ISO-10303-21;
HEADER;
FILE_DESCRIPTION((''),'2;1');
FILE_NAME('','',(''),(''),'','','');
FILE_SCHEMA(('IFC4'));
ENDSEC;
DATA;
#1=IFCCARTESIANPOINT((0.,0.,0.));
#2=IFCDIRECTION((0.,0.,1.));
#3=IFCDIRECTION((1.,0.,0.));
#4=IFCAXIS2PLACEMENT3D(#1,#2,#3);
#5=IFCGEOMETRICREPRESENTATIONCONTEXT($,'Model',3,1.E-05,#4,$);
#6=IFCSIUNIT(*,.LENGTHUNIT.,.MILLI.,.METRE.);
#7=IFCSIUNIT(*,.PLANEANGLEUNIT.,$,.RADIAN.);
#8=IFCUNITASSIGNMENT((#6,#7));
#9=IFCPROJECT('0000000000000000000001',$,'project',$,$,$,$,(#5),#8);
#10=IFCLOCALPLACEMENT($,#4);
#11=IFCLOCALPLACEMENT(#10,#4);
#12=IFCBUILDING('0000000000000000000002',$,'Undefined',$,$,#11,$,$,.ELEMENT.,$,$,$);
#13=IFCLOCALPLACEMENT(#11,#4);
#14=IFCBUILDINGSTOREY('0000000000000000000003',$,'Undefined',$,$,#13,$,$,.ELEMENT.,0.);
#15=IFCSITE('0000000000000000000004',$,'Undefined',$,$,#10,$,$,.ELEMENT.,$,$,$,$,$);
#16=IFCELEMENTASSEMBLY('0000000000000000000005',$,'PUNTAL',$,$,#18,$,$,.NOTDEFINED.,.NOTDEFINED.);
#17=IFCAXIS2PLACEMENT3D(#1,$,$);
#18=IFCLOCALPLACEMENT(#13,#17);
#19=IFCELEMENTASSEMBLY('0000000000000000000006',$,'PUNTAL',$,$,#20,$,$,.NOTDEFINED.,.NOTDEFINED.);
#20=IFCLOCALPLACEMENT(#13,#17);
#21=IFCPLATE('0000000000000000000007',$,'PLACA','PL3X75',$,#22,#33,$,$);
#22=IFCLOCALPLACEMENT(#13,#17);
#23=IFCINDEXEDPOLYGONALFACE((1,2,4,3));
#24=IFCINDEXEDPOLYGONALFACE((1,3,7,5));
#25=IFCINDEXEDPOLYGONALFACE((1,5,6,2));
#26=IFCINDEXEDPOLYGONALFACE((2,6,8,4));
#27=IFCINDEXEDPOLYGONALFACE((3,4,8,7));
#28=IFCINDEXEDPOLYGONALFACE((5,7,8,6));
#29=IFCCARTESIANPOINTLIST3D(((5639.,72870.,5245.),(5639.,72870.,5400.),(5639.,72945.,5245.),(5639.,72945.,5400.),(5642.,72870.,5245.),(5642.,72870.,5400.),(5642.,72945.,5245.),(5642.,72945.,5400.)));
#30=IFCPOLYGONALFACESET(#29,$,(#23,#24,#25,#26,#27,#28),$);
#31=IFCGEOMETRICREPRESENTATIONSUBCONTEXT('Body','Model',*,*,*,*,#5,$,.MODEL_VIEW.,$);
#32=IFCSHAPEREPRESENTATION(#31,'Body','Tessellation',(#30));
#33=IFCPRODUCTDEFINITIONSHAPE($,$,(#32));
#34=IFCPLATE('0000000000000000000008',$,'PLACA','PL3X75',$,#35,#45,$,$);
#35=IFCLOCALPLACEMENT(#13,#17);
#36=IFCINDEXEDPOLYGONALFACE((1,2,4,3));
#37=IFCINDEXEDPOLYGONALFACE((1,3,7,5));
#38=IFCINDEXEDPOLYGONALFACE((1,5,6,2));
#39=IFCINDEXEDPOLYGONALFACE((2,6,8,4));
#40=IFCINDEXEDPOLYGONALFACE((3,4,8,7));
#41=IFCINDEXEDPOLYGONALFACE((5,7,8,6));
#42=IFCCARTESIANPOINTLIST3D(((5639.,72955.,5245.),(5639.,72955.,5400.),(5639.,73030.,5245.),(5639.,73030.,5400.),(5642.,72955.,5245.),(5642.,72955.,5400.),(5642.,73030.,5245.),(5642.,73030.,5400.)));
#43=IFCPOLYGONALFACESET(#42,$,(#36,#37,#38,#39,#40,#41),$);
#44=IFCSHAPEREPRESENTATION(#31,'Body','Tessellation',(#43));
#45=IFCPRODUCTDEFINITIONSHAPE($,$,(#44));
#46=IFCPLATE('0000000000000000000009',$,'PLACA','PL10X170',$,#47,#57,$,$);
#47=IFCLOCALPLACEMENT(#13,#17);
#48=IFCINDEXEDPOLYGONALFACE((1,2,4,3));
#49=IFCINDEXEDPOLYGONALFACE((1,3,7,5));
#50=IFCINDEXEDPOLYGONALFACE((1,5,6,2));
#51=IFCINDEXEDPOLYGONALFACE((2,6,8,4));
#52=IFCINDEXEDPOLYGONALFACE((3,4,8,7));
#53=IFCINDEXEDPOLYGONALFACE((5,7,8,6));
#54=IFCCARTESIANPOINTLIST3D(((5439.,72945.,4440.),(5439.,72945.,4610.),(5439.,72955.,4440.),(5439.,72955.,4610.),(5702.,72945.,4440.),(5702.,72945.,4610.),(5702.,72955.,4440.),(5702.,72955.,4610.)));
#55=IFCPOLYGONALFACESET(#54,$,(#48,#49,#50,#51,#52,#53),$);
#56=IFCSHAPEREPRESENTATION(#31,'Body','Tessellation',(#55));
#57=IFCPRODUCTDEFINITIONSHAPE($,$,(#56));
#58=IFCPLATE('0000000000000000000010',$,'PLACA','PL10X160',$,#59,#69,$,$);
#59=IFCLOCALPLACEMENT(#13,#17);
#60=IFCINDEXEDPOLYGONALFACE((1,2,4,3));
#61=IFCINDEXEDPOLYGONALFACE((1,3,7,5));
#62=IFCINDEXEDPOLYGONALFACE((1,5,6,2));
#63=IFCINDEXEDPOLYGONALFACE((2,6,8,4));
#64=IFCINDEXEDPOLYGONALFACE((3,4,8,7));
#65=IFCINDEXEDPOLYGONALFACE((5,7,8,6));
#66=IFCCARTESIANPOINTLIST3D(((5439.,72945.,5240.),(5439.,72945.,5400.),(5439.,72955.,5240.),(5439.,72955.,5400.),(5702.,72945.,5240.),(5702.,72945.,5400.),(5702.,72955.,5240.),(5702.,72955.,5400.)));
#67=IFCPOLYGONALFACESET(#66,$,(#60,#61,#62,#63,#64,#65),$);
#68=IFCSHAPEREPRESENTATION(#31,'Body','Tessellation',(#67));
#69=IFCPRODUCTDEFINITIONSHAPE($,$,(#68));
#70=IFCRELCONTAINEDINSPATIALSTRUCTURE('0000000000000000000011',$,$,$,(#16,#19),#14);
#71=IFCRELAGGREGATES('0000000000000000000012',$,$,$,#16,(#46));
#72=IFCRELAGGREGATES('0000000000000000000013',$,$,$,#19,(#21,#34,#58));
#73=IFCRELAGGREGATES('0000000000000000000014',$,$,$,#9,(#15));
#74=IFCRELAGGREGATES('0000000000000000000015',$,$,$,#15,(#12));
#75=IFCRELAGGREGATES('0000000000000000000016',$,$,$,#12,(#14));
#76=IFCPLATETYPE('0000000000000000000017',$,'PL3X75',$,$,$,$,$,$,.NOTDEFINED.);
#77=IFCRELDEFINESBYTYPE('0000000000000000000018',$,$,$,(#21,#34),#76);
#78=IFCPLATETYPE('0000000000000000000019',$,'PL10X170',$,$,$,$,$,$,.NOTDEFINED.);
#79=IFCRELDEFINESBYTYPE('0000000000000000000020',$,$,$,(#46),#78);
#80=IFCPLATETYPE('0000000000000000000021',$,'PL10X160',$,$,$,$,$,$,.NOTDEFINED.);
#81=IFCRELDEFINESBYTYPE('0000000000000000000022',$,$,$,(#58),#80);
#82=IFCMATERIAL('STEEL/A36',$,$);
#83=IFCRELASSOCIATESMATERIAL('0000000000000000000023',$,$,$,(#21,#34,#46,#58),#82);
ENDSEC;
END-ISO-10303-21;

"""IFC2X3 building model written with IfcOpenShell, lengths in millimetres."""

from ifc_helpers import new_model, si_unit, frame, origin_with_axes, place, context, subcontext, project, spatial, polyline, outline, extrude, material, type_object, element, aggregate, save


model = new_model("IFC2X3")

# Units and contexts
model_context = context("Model", 3, precision=1e-05, world=origin_with_axes())
body_context = subcontext(model_context, "Body", "Model", "MODEL_VIEW")
ifc_project = project(units=[si_unit("LENGTHUNIT", "METRE", prefix="MILLI"), si_unit("PLANEANGLEUNIT", "RADIAN")], contexts=[model_context])

# Site, building, storey
site_placement = place(None, origin_with_axes())
site = spatial("IfcSite", under=ifc_project, at=site_placement, Name="Undefined", CompositionType="ELEMENT")
building_placement = place(site_placement, origin_with_axes())
building = spatial("IfcBuilding", under=site, at=building_placement, Name="Undefined", CompositionType="ELEMENT")
storey_placement = place(building_placement, origin_with_axes())
storey = spatial("IfcBuildingStorey", under=building, at=storey_placement, Name="Undefined", CompositionType="ELEMENT", Elevation=0.0)

# Shared definitions
ifc_material_1 = material(Name="STEEL/A36")

# Element assemblies, plates
assembly_1_placement = place(storey_placement, origin_with_axes())
assembly_1 = element("IfcElementAssembly", 1, at=assembly_1_placement, inside=storey, Name="PUNTAL", AssemblyPlace="NOTDEFINED", PredefinedType="NOTDEFINED")
plate_type_1 = type_object("IfcPlateType", Name="PL3X75", PredefinedType="NOTDEFINED")
assembly_2_placement = place(storey_placement, origin_with_axes())
assembly_2 = element("IfcElementAssembly", 2, at=assembly_2_placement, inside=storey, Name="PUNTAL", AssemblyPlace="NOTDEFINED", PredefinedType="NOTDEFINED")
plate_1_placement = place(assembly_2_placement, frame((5640.5, 72870.0, 5245.0), z_axis=(1.0, 0.0, 0.0), x_axis=(0.0, 1.0, 0.0)))
plate_1 = element("IfcPlate", 3, at=plate_1_placement, type_object=plate_type_1, material=ifc_material_1, Name="PLACA", Description="PL3X75", context=body_context, shape_type="SweptSolid", body=[
    extrude(outline(polyline([(0.0, 0.0), (75.0, 0.0), (75.0, 155.0), (0.0, 155.0), (0.0, 0.0)])), frame((0.0, 0.0, -1.5), z_axis=(0.0, 0.0, 1.0), x_axis=(1.0, 0.0, 0.0)), (0.0, 0.0, 1.0), 3.0),
])
plate_2_placement = place(assembly_2_placement, frame((5640.5, 72955.0, 5245.0), z_axis=(1.0, 0.0, 0.0), x_axis=(0.0, 1.0, 0.0)))
plate_2 = element("IfcPlate", 4, at=plate_2_placement, type_object=plate_type_1, material=ifc_material_1, Name="PLACA", Description="PL3X75", context=body_context, shape_type="SweptSolid", body=[
    extrude(outline(polyline([(0.0, 0.0), (75.0, 0.0), (75.0, 155.0), (0.0, 155.0), (0.0, 0.0)])), frame((0.0, 0.0, -1.5), z_axis=(0.0, 0.0, 1.0), x_axis=(1.0, 0.0, 0.0)), (0.0, 0.0, 1.0), 3.0),
])

# Plates
plate_type_2 = type_object("IfcPlateType", Name="PL10X170", PredefinedType="NOTDEFINED")
plate_3_placement = place(assembly_1_placement, frame((5702.0, 72950.0, 4525.0), z_axis=(0.0, 1.0, 0.0), x_axis=(-1.0, 0.0, 0.0)))
plate_3 = element("IfcPlate", 5, at=plate_3_placement, type_object=plate_type_2, material=ifc_material_1, Name="PLACA", Description="PL10X170", context=body_context, shape_type="SweptSolid", body=[
    extrude(outline(polyline([(0.0, -85.0), (0.0, 85.0), (263.0, 85.0), (263.0, -85.0), (0.0, -85.0)])), frame((0.0, 0.0, -5.0), z_axis=(0.0, 0.0, 1.0), x_axis=(1.0, 0.0, 0.0)), (0.0, 0.0, 1.0), 10.0),
])
aggregate(assembly_1, [plate_3])
plate_type_3 = type_object("IfcPlateType", Name="PL10X160", PredefinedType="NOTDEFINED")
plate_4_placement = place(assembly_2_placement, frame((5702.0, 72950.0, 5320.0), z_axis=(0.0, -1.0, 0.0), x_axis=(-1.0, 0.0, 0.0)))
plate_4 = element("IfcPlate", 6, at=plate_4_placement, type_object=plate_type_3, material=ifc_material_1, Name="PLACA", Description="PL10X160", context=body_context, shape_type="SweptSolid", body=[
    extrude(outline(polyline([(0.0, -80.0), (0.0, 80.0), (263.0, 80.0), (263.0, -80.0), (0.0, -80.0)])), frame((0.0, 0.0, -5.0), z_axis=(0.0, 0.0, 1.0), x_axis=(1.0, 0.0, 0.0)), (0.0, 0.0, 1.0), 10.0),
])
aggregate(assembly_2, [plate_1, plate_2, plate_4])

save(model, "model.ifc")
